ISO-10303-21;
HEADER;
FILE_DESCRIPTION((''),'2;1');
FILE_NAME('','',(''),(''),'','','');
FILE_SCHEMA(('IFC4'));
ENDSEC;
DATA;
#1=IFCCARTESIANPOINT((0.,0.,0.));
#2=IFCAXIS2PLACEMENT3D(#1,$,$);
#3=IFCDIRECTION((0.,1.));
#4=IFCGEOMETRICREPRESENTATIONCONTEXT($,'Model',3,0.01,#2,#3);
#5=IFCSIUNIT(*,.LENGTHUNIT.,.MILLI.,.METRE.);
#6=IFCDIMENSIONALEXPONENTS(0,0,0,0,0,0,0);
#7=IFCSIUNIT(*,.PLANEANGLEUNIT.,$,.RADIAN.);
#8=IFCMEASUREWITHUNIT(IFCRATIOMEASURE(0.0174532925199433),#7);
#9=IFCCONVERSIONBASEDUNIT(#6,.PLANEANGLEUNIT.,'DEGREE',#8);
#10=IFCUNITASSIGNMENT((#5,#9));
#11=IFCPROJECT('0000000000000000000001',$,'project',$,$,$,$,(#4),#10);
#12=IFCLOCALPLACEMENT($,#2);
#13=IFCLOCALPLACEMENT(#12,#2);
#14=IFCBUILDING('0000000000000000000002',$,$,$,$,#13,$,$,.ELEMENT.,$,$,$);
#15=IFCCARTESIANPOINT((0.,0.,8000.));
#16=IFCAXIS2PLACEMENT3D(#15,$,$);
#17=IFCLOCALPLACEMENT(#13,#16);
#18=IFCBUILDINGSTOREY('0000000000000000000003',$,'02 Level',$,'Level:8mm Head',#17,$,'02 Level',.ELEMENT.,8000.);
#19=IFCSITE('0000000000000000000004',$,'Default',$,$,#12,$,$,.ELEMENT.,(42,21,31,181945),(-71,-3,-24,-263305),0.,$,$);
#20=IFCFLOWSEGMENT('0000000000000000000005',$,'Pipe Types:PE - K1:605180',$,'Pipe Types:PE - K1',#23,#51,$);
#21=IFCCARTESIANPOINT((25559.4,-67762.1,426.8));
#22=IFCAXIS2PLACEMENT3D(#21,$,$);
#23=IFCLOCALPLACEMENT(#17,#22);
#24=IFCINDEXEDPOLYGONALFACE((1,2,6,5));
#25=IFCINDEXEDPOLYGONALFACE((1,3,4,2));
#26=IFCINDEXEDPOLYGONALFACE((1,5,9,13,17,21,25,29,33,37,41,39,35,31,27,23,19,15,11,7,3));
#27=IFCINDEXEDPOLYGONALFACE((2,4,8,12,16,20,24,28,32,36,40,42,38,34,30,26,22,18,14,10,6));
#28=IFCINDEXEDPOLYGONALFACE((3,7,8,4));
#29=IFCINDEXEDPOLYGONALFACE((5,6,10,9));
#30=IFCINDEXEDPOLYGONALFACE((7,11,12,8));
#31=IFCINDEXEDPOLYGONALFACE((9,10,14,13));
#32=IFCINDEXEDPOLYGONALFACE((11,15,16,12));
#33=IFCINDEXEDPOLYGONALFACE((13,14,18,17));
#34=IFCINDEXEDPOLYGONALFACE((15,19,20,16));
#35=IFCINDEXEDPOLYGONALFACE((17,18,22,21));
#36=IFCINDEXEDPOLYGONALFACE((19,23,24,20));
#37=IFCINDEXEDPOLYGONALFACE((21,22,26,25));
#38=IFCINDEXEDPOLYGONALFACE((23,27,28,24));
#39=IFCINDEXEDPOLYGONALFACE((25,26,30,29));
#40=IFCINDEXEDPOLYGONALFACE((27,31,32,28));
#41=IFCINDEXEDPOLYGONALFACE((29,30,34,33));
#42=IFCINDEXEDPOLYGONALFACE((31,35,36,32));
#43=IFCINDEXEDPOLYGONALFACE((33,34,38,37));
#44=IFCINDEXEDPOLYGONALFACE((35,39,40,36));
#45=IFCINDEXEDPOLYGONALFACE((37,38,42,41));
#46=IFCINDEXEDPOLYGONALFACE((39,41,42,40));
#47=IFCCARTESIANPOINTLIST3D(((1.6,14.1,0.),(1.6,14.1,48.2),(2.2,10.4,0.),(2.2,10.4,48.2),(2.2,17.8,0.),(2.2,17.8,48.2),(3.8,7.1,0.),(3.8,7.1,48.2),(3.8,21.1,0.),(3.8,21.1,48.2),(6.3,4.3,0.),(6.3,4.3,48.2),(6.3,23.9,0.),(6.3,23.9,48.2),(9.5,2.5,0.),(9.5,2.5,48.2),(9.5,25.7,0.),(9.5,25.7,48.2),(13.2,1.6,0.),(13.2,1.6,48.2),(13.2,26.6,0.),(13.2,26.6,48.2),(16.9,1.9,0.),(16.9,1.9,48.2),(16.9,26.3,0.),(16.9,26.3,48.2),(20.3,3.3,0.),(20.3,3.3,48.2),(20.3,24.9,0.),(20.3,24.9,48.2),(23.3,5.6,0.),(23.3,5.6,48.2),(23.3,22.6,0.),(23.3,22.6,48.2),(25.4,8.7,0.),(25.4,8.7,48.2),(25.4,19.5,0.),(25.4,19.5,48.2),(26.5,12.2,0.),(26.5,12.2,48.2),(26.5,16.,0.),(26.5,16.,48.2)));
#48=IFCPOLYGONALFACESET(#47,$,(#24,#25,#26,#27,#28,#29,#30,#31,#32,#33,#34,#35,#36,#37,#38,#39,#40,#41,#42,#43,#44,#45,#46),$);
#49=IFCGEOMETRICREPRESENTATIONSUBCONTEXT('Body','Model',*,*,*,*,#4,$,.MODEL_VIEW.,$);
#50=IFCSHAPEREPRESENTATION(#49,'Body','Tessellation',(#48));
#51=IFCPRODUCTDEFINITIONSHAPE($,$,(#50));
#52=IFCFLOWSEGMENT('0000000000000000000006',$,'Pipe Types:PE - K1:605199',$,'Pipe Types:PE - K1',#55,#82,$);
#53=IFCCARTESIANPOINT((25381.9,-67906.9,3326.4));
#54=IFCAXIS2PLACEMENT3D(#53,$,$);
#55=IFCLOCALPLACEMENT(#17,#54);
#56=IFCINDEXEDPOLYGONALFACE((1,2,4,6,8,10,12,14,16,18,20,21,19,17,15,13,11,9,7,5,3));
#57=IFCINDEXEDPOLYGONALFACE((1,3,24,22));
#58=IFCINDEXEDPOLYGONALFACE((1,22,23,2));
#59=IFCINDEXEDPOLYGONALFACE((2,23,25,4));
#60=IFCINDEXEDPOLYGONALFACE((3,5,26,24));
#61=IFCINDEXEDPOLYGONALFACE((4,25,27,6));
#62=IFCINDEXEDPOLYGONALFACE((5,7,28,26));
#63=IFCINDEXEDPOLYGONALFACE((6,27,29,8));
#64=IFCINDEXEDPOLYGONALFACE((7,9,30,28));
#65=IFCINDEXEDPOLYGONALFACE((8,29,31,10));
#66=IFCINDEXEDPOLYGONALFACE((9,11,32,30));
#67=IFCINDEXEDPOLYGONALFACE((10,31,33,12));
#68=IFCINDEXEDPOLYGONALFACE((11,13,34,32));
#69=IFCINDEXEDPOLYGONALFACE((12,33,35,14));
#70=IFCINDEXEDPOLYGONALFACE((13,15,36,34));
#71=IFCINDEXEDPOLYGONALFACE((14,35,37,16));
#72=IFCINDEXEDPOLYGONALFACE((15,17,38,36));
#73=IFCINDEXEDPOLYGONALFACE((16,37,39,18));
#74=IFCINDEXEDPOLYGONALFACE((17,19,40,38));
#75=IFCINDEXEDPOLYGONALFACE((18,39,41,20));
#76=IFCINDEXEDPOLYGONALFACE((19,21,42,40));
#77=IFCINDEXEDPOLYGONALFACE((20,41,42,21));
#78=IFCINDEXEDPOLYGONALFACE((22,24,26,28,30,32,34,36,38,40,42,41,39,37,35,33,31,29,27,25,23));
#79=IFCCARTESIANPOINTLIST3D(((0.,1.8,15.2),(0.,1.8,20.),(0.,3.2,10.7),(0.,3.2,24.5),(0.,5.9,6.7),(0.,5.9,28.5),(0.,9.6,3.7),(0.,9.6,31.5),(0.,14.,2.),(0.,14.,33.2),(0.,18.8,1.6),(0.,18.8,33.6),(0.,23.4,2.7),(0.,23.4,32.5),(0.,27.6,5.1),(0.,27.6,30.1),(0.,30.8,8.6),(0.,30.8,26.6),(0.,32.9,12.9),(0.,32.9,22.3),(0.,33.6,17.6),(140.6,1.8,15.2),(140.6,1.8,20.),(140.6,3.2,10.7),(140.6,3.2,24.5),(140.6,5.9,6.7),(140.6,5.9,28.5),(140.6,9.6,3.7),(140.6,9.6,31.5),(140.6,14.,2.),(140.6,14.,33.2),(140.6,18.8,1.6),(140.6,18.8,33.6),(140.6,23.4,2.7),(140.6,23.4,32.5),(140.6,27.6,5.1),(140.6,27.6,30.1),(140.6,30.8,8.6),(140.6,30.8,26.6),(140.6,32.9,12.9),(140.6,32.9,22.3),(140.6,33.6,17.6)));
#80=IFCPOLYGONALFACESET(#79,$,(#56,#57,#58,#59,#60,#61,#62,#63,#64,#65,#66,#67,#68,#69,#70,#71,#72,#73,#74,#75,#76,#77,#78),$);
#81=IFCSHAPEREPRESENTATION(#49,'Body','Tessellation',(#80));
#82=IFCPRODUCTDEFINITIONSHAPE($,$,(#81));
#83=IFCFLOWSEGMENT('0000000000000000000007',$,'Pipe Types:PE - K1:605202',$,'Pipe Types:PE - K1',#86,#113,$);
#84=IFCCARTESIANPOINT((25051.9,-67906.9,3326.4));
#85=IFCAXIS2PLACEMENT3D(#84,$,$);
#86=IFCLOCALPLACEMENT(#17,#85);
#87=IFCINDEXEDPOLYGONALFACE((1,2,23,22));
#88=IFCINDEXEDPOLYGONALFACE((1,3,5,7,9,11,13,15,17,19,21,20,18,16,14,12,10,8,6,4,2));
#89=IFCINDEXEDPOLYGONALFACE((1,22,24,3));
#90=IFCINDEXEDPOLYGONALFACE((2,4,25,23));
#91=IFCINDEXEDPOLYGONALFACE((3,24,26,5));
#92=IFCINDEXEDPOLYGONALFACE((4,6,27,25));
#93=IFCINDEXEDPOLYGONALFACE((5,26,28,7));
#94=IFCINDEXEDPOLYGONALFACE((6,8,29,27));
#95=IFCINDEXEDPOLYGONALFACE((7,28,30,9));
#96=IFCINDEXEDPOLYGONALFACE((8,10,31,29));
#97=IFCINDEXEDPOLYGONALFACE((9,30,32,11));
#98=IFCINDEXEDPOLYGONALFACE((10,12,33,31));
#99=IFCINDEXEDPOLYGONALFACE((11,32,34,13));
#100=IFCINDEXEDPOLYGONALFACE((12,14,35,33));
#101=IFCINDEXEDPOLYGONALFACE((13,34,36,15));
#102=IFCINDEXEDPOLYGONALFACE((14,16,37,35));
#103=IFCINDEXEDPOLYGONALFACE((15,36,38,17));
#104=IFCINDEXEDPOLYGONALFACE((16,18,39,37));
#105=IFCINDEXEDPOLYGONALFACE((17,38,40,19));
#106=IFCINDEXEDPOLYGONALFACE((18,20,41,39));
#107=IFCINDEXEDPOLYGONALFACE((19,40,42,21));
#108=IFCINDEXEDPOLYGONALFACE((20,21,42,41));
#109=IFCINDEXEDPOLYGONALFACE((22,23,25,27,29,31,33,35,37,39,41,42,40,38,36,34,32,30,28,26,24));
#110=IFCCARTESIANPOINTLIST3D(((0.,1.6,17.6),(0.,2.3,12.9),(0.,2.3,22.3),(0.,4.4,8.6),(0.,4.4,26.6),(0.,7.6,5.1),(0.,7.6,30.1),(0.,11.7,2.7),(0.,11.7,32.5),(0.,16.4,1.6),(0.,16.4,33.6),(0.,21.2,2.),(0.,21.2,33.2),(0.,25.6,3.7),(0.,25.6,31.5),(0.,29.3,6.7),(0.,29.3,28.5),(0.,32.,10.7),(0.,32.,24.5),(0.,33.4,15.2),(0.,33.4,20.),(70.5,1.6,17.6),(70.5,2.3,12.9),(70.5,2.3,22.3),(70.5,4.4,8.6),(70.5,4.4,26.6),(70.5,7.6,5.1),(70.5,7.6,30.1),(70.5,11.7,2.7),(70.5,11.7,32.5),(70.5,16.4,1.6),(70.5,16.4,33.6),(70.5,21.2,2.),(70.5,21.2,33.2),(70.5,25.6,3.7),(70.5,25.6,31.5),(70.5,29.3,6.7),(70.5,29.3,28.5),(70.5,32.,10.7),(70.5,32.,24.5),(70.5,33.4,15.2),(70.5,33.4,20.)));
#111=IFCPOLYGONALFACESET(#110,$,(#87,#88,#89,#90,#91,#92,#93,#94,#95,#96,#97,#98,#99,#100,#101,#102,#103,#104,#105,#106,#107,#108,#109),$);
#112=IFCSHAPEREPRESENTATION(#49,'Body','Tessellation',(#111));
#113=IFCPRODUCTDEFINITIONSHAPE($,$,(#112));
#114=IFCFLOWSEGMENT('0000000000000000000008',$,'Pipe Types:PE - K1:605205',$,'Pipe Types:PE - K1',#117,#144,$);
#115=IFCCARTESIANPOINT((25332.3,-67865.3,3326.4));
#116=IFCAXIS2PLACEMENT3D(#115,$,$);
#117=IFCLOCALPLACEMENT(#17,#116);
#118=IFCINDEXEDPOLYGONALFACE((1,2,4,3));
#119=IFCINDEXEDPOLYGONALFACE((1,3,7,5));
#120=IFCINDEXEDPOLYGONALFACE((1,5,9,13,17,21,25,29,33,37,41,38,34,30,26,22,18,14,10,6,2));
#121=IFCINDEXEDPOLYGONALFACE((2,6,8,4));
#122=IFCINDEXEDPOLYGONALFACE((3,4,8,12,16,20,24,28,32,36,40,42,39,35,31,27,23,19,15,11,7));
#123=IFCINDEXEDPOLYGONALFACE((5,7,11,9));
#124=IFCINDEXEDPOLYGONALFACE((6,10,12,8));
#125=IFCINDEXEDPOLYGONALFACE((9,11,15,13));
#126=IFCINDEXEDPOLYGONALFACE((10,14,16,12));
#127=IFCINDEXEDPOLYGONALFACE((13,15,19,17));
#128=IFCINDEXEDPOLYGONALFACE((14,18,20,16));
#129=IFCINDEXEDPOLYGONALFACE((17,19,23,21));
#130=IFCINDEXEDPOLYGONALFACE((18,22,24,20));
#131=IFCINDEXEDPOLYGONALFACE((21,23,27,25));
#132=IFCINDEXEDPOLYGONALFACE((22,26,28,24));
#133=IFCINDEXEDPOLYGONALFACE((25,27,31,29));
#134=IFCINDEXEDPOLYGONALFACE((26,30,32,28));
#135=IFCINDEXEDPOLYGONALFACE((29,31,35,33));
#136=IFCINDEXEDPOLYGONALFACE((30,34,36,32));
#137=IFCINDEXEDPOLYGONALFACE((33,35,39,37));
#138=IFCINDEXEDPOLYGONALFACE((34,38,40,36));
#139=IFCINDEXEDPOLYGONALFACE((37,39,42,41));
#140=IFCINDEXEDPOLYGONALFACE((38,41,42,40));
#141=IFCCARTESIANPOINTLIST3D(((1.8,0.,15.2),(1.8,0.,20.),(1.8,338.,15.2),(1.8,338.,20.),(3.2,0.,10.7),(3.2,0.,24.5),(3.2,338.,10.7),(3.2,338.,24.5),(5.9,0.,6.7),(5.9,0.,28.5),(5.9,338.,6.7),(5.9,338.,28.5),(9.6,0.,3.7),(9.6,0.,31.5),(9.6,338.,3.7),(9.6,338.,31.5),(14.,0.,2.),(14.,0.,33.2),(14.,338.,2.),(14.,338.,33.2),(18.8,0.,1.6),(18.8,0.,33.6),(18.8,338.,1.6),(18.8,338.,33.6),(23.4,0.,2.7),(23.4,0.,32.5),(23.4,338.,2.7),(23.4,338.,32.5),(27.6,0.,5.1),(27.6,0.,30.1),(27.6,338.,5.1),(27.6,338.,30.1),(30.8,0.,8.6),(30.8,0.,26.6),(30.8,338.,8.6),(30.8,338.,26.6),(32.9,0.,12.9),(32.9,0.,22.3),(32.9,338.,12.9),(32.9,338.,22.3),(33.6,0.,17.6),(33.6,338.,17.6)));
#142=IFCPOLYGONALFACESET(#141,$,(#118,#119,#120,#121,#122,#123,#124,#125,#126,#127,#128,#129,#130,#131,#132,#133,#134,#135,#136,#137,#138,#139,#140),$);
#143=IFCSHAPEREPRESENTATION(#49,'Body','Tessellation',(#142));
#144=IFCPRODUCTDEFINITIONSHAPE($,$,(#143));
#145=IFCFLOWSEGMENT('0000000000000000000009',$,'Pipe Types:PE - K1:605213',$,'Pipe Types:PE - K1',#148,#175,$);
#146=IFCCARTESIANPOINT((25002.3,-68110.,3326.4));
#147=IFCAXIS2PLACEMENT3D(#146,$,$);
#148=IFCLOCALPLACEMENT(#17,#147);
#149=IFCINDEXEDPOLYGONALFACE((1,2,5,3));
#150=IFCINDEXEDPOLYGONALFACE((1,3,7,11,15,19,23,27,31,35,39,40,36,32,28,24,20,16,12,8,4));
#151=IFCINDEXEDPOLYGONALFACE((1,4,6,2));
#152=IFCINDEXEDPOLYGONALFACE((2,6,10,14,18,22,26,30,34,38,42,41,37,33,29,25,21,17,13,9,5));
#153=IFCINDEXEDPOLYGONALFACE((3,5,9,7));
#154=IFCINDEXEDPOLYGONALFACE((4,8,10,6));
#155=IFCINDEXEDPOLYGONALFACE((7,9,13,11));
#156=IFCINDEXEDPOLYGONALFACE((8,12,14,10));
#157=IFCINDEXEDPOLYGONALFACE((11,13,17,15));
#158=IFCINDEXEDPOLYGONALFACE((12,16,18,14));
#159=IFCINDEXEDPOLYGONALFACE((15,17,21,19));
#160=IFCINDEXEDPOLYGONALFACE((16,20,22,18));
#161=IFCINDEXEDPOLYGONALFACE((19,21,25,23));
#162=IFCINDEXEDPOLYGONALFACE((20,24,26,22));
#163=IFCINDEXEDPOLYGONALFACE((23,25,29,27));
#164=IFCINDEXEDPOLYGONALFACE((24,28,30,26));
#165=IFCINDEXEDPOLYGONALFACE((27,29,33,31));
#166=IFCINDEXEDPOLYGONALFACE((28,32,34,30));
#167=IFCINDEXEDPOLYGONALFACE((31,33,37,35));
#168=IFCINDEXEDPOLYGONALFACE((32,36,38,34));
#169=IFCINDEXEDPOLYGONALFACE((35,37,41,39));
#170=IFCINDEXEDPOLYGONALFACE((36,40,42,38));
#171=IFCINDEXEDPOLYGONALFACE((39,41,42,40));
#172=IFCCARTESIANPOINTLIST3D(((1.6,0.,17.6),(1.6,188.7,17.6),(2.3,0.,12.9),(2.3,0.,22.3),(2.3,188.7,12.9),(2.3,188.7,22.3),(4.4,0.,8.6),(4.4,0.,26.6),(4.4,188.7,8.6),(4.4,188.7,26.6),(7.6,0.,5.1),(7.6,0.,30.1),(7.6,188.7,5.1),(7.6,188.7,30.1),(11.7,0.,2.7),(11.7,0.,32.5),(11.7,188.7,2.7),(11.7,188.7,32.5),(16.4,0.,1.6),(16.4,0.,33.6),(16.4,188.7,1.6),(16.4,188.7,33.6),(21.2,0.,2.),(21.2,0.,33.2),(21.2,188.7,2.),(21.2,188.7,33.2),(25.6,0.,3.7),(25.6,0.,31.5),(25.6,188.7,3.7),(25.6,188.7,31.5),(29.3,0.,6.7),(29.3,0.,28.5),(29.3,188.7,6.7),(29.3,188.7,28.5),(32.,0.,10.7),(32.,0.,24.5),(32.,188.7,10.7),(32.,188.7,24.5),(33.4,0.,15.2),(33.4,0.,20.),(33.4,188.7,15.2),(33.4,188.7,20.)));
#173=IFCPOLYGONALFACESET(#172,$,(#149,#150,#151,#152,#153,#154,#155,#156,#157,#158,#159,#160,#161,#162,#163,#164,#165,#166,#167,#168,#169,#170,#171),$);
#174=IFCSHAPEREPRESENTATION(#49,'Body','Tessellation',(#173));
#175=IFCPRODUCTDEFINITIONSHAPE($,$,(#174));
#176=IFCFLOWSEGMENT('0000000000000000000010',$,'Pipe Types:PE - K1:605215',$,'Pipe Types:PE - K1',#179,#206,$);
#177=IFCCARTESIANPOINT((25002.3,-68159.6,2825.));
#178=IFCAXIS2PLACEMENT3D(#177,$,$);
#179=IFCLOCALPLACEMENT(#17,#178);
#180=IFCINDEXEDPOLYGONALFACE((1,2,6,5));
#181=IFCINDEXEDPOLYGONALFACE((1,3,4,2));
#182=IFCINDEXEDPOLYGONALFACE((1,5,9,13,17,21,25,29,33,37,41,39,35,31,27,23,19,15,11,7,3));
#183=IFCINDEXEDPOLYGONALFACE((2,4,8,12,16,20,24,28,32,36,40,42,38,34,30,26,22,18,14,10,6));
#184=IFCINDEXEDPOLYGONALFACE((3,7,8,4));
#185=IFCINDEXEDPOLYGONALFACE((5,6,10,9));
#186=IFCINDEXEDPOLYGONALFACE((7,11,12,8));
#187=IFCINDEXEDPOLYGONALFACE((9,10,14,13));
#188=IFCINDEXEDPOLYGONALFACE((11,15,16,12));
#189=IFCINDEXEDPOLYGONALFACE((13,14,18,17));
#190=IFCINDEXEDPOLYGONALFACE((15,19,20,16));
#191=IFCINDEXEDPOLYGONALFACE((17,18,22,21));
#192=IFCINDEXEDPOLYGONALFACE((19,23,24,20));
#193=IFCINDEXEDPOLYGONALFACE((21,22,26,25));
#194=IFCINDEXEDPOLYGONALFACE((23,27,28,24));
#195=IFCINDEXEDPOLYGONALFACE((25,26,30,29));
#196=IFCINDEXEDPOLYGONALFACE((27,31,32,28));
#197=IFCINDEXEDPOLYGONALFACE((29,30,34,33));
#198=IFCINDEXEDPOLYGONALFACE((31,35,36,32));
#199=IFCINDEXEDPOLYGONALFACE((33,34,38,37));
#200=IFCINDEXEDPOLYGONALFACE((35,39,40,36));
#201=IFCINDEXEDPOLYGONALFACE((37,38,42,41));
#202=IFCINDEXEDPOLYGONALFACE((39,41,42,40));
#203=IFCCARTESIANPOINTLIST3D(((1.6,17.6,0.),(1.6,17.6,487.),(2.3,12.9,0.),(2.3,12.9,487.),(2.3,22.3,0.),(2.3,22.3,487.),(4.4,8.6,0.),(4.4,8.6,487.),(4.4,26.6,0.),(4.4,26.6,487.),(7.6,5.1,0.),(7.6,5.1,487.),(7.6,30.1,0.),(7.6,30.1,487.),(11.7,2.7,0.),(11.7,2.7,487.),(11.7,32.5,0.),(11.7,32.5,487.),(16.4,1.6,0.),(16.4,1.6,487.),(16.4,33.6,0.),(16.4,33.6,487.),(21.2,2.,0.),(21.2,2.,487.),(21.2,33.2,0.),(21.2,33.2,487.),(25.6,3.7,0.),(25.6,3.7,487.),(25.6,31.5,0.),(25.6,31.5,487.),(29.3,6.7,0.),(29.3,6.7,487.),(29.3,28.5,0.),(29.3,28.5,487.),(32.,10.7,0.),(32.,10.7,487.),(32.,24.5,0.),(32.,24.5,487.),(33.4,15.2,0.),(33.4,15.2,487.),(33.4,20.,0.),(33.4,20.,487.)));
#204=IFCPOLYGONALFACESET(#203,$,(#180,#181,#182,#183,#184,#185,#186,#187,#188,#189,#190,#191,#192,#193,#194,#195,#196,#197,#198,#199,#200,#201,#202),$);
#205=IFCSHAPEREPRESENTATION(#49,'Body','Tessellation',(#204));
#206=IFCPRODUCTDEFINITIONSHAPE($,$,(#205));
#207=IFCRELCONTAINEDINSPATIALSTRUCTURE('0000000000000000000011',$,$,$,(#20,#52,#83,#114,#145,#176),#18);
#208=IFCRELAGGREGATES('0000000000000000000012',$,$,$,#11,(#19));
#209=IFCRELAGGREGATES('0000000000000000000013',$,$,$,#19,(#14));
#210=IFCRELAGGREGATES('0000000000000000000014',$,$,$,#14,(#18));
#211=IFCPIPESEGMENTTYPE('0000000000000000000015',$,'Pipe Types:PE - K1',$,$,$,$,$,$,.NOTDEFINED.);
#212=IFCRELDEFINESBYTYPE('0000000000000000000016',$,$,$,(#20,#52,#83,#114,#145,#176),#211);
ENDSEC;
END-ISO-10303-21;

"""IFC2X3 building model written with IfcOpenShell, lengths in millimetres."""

from ifc_helpers import new_model, entity, si_unit, converted_unit, direction, frame, frame_2d, origin, origin_2d_with_axis, place, context, subcontext, project, spatial, circle, extrude, type_object, element, save


model = new_model("IFC2X3")

# Units and contexts
model_context = context("Model", 3, precision=0.01, world=origin(), true_north=direction((0.0, 1.0)))
body_context = subcontext(model_context, "Body", "Model", "MODEL_VIEW")
ifc_project = project(units=[si_unit("LENGTHUNIT", "METRE", prefix="MILLI"), converted_unit("PLANEANGLEUNIT", "DEGREE", entity("IfcRatioMeasure", 0.0174532925199433), si_unit("PLANEANGLEUNIT", "RADIAN"), dimensions=[0, 0, 0, 0, 0, 0, 0])], contexts=[model_context])

# Site, building, storey
site_placement = place(None, origin())
site = spatial("IfcSite", under=ifc_project, at=site_placement, Name="Default", CompositionType="ELEMENT", RefLatitude=(42, 21, 31, 181945), RefLongitude=(-71, -3, -24, -263305), RefElevation=0.0)
building_placement = place(site_placement, origin())
building = spatial("IfcBuilding", under=site, at=building_placement, CompositionType="ELEMENT")
storey_placement = place(building_placement, frame((0.0, 0.0, 8000.0)))
storey = spatial("IfcBuildingStorey", under=building, at=storey_placement, Name="02 Level", ObjectType="Level:8mm Head", LongName="02 Level", CompositionType="ELEMENT", Elevation=8000.0)

# Flow segments
pipe_segment_type = type_object("IfcPipeSegmentType", Name="Pipe Types:PE - K1", PredefinedType="NOTDEFINED")
flow_segment_1_placement = place(storey_placement, frame((25559.4, -67762.1, 426.8)))
element("IfcFlowSegment", 1, at=flow_segment_1_placement, inside=storey, type_object=pipe_segment_type, Name="Pipe Types:PE - K1:605180", ObjectType="Pipe Types:PE - K1", context=body_context, shape_type="SweptSolid", body=[
    extrude(circle(Radius=12.5, at=origin_2d_with_axis()), frame((14.1, 14.1, 0.0), z_axis=(0.0, 0.0, 1.0), x_axis=(-1.0, 0.0, 0.0)), (0.0, 0.0, 1.0), 48.2),
])
flow_segment_2_placement = place(storey_placement, frame((25381.9, -67906.9, 3326.4)))
element("IfcFlowSegment", 2, at=flow_segment_2_placement, inside=storey, type_object=pipe_segment_type, Name="Pipe Types:PE - K1:605199", ObjectType="Pipe Types:PE - K1", context=body_context, shape_type="SweptSolid", body=[
    extrude(circle(Radius=16.0, at=frame_2d((0.0, 0.0), x_axis=(1.0, 0.0))), frame((0.0, 17.6, 17.6), z_axis=(1.0, 0.0, 0.0), x_axis=(0.0, 1.0, 0.0)), (0.0, 0.0, 1.0), 140.6),
])
flow_segment_3_placement = place(storey_placement, frame((25051.9, -67906.9, 3326.4)))
element("IfcFlowSegment", 3, at=flow_segment_3_placement, inside=storey, type_object=pipe_segment_type, Name="Pipe Types:PE - K1:605202", ObjectType="Pipe Types:PE - K1", context=body_context, shape_type="SweptSolid", body=[
    extrude(circle(Radius=16.0, at=origin_2d_with_axis()), frame((0.0, 17.6, 17.6), z_axis=(1.0, 0.0, 0.0), x_axis=(0.0, -1.0, 0.0)), (0.0, 0.0, 1.0), 70.5),
])
flow_segment_4_placement = place(storey_placement, frame((25332.3, -67865.3, 3326.4)))
element("IfcFlowSegment", 4, at=flow_segment_4_placement, inside=storey, type_object=pipe_segment_type, Name="Pipe Types:PE - K1:605205", ObjectType="Pipe Types:PE - K1", context=body_context, shape_type="SweptSolid", body=[
    extrude(circle(Radius=16.0, at=origin_2d_with_axis()), frame((17.6, 0.0, 17.6), z_axis=(0.0, 1.0, 0.0), x_axis=(1.0, 0.0, 0.0)), (0.0, 0.0, 1.0), 338.0),
])
flow_segment_5_placement = place(storey_placement, frame((25002.3, -68110.0, 3326.4)))
element("IfcFlowSegment", 5, at=flow_segment_5_placement, inside=storey, type_object=pipe_segment_type, Name="Pipe Types:PE - K1:605213", ObjectType="Pipe Types:PE - K1", context=body_context, shape_type="SweptSolid", body=[
    extrude(circle(Radius=16.0, at=frame_2d((0.0, 0.0), x_axis=(1.0, 0.0))), frame((17.6, 0.0, 17.6), z_axis=(0.0, 1.0, 0.0), x_axis=(-1.0, 0.0, 0.0)), (0.0, 0.0, 1.0), 188.7),
])
flow_segment_6_placement = place(storey_placement, frame((25002.3, -68159.6, 2825.0)))
element("IfcFlowSegment", 6, at=flow_segment_6_placement, inside=storey, type_object=pipe_segment_type, Name="Pipe Types:PE - K1:605215", ObjectType="Pipe Types:PE - K1", context=body_context, shape_type="SweptSolid", body=[
    extrude(circle(Radius=16.0, at=origin_2d_with_axis()), frame((17.6, 17.6, 0.0), z_axis=(0.0, 0.0, 1.0), x_axis=(-1.0, 0.0, 0.0)), (0.0, 0.0, 1.0), 487.0),
])

save(model, "model.ifc")
